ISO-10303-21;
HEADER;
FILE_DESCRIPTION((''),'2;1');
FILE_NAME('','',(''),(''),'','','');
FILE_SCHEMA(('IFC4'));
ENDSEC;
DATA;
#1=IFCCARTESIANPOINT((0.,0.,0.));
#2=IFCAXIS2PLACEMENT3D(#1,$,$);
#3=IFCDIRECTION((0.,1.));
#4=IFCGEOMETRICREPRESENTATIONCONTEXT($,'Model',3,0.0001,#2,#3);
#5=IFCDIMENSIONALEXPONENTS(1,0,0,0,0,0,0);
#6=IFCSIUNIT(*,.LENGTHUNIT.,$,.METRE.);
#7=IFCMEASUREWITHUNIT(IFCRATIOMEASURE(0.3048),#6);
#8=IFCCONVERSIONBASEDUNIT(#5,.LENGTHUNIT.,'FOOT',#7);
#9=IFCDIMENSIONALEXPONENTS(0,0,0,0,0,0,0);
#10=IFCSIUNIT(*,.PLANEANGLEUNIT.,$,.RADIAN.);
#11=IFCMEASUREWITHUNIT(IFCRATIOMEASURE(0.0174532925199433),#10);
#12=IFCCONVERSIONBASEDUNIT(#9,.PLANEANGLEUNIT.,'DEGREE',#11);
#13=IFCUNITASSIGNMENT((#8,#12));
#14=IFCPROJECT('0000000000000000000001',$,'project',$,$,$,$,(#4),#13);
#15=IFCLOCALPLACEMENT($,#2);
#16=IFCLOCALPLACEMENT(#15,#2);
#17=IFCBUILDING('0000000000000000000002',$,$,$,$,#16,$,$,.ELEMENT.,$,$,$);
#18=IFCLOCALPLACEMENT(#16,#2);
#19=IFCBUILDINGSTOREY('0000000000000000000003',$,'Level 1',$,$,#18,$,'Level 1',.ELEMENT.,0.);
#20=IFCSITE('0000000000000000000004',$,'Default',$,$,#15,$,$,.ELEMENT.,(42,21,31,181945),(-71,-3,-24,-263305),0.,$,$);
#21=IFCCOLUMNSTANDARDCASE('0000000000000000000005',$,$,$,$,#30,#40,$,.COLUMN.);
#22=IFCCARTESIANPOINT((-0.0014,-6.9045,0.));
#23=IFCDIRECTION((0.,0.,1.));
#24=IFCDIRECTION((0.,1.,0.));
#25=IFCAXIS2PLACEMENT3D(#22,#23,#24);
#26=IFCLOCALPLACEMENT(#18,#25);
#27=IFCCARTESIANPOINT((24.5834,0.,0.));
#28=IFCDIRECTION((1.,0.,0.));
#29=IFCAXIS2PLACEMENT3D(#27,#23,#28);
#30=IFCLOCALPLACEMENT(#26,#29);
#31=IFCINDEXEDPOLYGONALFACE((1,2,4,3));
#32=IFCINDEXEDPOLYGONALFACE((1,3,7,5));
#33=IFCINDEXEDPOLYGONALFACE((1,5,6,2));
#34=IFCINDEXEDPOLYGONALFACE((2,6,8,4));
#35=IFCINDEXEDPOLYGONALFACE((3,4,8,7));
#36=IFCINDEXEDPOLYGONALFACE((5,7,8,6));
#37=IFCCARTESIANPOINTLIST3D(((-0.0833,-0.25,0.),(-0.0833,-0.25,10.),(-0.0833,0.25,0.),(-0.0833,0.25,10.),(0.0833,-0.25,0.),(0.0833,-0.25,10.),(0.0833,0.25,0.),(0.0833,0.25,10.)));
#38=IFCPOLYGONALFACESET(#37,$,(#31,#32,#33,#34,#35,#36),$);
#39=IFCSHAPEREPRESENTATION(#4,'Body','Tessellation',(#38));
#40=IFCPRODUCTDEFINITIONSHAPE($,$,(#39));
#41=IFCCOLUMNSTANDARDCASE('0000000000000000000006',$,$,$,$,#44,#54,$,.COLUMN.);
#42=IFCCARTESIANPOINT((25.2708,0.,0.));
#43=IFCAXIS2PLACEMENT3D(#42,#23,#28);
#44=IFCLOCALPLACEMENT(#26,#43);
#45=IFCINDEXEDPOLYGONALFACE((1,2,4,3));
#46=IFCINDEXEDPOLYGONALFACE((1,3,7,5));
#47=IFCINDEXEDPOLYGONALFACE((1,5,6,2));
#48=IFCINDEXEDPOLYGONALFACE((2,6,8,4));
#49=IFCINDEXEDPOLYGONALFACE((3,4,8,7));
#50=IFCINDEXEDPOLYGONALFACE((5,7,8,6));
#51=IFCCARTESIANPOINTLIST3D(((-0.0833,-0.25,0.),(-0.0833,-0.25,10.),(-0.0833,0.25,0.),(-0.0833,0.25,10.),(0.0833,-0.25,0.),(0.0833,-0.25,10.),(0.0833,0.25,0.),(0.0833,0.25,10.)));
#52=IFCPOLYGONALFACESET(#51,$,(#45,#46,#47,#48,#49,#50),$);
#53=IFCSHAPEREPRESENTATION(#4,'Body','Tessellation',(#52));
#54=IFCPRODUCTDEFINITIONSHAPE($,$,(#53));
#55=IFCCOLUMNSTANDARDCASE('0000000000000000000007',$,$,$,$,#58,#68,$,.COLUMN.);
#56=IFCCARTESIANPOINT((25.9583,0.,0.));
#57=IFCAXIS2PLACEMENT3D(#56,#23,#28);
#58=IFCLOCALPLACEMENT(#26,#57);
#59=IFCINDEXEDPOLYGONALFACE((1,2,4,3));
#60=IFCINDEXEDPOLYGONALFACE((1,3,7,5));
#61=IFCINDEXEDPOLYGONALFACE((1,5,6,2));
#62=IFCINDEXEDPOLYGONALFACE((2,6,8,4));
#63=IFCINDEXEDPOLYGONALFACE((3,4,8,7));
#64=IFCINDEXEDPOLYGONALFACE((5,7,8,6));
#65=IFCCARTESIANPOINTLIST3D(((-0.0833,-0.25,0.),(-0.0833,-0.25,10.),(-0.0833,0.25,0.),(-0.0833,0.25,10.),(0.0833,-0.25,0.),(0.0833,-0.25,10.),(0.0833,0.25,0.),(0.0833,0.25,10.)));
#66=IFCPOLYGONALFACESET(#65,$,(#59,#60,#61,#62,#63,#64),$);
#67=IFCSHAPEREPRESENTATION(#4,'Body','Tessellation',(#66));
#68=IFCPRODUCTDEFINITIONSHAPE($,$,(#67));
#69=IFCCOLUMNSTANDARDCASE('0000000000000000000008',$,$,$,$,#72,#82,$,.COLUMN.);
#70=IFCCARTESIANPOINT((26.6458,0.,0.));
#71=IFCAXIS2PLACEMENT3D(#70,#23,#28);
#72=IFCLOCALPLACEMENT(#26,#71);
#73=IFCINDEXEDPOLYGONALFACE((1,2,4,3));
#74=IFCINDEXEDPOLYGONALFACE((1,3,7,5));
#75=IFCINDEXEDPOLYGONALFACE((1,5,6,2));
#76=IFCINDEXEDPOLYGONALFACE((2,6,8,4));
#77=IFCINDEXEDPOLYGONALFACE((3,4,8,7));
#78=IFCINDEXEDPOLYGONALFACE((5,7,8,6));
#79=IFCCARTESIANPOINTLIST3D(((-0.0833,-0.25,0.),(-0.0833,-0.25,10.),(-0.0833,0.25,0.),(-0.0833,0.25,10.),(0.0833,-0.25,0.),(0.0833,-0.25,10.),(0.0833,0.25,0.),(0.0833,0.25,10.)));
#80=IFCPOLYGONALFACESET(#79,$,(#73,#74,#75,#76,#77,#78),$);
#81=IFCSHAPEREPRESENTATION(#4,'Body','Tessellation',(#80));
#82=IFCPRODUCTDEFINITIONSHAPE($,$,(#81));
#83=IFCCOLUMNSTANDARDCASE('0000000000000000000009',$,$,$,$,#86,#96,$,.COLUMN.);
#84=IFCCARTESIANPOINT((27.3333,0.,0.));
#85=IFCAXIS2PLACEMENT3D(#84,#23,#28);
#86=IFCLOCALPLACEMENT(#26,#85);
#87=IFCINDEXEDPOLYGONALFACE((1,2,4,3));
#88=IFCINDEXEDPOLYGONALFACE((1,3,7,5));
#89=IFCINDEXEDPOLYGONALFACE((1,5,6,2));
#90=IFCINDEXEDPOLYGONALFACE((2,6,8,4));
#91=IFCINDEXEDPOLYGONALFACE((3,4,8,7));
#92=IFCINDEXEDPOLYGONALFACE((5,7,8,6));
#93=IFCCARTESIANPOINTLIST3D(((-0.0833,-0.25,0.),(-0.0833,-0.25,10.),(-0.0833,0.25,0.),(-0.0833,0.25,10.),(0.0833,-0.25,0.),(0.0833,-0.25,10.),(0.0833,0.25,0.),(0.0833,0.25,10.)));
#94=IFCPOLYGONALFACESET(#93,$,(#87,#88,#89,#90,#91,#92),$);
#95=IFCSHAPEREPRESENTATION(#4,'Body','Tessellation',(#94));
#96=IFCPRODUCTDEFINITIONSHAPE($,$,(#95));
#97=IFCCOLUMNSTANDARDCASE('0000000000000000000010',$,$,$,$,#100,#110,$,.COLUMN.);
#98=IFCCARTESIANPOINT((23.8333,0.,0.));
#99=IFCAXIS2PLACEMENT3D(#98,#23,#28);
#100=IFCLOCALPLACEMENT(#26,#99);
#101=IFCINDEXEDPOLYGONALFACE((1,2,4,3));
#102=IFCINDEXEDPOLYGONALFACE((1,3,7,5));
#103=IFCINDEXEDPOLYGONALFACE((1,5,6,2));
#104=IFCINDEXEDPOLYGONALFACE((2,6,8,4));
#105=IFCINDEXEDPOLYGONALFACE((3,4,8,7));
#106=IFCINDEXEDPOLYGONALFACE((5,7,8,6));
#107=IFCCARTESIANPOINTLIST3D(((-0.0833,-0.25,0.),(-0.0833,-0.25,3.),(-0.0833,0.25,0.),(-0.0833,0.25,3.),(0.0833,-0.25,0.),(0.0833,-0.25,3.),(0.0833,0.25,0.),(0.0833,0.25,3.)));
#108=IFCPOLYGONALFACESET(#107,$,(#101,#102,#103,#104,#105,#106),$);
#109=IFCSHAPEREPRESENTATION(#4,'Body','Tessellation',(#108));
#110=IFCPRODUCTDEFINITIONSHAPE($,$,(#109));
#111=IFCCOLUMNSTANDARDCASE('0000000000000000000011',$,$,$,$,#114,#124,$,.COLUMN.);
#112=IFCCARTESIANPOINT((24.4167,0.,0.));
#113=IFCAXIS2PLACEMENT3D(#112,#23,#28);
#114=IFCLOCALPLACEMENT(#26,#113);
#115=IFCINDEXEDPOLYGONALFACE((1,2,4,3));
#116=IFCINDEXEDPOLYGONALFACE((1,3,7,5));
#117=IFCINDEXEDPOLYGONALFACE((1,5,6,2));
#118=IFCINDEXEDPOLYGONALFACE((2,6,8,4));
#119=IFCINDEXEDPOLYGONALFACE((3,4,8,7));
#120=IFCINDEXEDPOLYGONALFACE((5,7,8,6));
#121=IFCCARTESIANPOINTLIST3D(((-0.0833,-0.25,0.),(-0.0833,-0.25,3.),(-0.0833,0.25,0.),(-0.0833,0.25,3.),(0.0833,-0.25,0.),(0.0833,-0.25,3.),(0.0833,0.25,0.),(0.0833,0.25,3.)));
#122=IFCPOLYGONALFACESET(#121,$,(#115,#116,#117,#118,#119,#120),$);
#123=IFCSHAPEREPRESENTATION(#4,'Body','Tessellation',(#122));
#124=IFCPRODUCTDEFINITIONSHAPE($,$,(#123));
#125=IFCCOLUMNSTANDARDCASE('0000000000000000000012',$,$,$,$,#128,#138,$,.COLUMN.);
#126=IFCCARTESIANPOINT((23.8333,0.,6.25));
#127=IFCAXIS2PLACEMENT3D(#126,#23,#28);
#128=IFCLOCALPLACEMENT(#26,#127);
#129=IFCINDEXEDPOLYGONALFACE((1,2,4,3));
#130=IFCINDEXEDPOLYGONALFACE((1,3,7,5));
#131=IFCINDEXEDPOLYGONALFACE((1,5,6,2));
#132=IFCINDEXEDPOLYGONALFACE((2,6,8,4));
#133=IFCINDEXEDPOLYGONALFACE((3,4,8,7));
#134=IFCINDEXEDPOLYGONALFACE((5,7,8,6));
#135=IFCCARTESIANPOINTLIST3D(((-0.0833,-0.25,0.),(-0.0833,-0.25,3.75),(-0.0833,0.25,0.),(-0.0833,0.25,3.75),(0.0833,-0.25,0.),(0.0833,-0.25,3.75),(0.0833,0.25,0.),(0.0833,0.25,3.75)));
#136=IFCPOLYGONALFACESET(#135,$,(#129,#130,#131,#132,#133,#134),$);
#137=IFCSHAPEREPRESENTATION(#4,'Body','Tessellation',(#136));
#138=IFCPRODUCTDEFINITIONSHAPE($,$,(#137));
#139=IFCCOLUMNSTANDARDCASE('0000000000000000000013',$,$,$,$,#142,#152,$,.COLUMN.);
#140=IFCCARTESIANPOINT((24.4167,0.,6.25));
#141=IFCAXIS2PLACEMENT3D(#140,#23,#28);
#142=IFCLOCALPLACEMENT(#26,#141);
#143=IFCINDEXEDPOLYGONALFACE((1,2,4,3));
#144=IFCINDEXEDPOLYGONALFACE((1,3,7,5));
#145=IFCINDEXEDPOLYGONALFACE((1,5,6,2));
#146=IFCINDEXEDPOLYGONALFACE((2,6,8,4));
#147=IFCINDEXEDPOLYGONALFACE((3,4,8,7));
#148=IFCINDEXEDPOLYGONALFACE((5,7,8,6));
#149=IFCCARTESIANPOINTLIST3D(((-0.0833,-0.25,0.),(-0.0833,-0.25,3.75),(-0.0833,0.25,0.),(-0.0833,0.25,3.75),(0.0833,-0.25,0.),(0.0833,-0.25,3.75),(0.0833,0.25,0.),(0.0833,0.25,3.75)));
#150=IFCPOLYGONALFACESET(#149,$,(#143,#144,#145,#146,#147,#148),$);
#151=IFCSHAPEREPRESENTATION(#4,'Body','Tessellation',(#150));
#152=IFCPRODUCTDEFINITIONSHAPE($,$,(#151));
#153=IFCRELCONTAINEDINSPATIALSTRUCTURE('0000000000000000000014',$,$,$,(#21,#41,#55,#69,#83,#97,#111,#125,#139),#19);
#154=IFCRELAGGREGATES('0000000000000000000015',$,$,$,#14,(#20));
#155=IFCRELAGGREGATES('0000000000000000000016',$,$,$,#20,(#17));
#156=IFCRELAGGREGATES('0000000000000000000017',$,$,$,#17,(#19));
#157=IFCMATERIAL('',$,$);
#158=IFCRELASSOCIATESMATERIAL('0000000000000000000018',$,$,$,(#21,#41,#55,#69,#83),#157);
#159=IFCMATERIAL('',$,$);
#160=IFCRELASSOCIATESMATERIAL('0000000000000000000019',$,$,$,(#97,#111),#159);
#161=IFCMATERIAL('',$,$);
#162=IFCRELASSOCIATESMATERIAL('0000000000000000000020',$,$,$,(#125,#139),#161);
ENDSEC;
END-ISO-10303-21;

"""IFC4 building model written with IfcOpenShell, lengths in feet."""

from ifc_helpers import new_model, entity, si_unit, converted_unit, direction, frame, origin, place, context, project, spatial, rectangle, extrude, material, element, save


model = new_model("IFC4")

# Units and contexts
model_context = context("Model", 3, precision=0.0001, world=origin(), true_north=direction((0.0, 1.0)))
ifc_project = project(units=[converted_unit("LENGTHUNIT", "FOOT", entity("IfcRatioMeasure", 0.3048), si_unit("LENGTHUNIT", "METRE"), dimensions=[1, 0, 0, 0, 0, 0, 0]), converted_unit("PLANEANGLEUNIT", "DEGREE", entity("IfcRatioMeasure", 0.0174532925199433), si_unit("PLANEANGLEUNIT", "RADIAN"), dimensions=[0, 0, 0, 0, 0, 0, 0])], contexts=[model_context])

# Site, building, storey
site_placement = place(None, origin())
site = spatial("IfcSite", under=ifc_project, at=site_placement, Name="Default", CompositionType="ELEMENT", RefLatitude=(42, 21, 31, 181945), RefLongitude=(-71, -3, -24, -263305), RefElevation=0.0)
building_placement = place(site_placement, origin())
building = spatial("IfcBuilding", under=site, at=building_placement, CompositionType="ELEMENT")
storey_placement = place(building_placement, origin())
storey = spatial("IfcBuildingStorey", under=building, at=storey_placement, Name="Level 1", LongName="Level 1", CompositionType="ELEMENT", Elevation=0.0)

# Columns
ifc_material_1 = material(Name="")
placement = place(storey_placement, frame((-0.0014, -6.9045, 0.0), z_axis=(0.0, 0.0, 1.0), x_axis=(0.0, 1.0, 0.0)))
for number, where, z_axis, x_axis in (
    (1, (24.5834, 0.0, 0.0), (0.0, 0.0, 1.0), (1.0, 0.0, 0.0)),
    (2, (25.2708, 0.0, 0.0), (0.0, 0.0, 1.0), (1.0, 0.0, 0.0)),
    (3, (25.9583, 0.0, 0.0), (0.0, 0.0, 1.0), (1.0, 0.0, 0.0)),
    (4, (26.6458, 0.0, 0.0), (0.0, 0.0, 1.0), (1.0, 0.0, 0.0)),
    (5, (27.3333, 0.0, 0.0), (0.0, 0.0, 1.0), (1.0, 0.0, 0.0)),
):
    element("IfcColumnStandardCase", number, at=place(placement, frame(where, z_axis=z_axis, x_axis=x_axis)), inside=storey, material=ifc_material_1, PredefinedType="COLUMN", context=model_context, shape_type="SweptSolid", body=[
        extrude(rectangle(XDim=0.1667, YDim=0.5), origin(), (0.0, 0.0, 1.0), 10.0),
    ])
ifc_material_2 = material(Name="")
for number, where, z_axis, x_axis in (
    (6, (23.8333, 0.0, 0.0), (0.0, 0.0, 1.0), (1.0, 0.0, 0.0)),
    (7, (24.4167, 0.0, 0.0), (0.0, 0.0, 1.0), (1.0, 0.0, 0.0)),
):
    element("IfcColumnStandardCase", number, at=place(placement, frame(where, z_axis=z_axis, x_axis=x_axis)), inside=storey, material=ifc_material_2, PredefinedType="COLUMN", context=model_context, shape_type="SweptSolid", body=[
        extrude(rectangle(XDim=0.1667, YDim=0.5), origin(), (0.0, 0.0, 1.0), 3.0),
    ])
ifc_material_3 = material(Name="")
for number, where, z_axis, x_axis in (
    (8, (23.8333, 0.0, 6.25), (0.0, 0.0, 1.0), (1.0, 0.0, 0.0)),
    (9, (24.4167, 0.0, 6.25), (0.0, 0.0, 1.0), (1.0, 0.0, 0.0)),
):
    element("IfcColumnStandardCase", number, at=place(placement, frame(where, z_axis=z_axis, x_axis=x_axis)), inside=storey, material=ifc_material_3, PredefinedType="COLUMN", context=model_context, shape_type="SweptSolid", body=[
        extrude(rectangle(XDim=0.1667, YDim=0.5), origin(), (0.0, 0.0, 1.0), 3.75),
    ])

save(model, "model.ifc")
